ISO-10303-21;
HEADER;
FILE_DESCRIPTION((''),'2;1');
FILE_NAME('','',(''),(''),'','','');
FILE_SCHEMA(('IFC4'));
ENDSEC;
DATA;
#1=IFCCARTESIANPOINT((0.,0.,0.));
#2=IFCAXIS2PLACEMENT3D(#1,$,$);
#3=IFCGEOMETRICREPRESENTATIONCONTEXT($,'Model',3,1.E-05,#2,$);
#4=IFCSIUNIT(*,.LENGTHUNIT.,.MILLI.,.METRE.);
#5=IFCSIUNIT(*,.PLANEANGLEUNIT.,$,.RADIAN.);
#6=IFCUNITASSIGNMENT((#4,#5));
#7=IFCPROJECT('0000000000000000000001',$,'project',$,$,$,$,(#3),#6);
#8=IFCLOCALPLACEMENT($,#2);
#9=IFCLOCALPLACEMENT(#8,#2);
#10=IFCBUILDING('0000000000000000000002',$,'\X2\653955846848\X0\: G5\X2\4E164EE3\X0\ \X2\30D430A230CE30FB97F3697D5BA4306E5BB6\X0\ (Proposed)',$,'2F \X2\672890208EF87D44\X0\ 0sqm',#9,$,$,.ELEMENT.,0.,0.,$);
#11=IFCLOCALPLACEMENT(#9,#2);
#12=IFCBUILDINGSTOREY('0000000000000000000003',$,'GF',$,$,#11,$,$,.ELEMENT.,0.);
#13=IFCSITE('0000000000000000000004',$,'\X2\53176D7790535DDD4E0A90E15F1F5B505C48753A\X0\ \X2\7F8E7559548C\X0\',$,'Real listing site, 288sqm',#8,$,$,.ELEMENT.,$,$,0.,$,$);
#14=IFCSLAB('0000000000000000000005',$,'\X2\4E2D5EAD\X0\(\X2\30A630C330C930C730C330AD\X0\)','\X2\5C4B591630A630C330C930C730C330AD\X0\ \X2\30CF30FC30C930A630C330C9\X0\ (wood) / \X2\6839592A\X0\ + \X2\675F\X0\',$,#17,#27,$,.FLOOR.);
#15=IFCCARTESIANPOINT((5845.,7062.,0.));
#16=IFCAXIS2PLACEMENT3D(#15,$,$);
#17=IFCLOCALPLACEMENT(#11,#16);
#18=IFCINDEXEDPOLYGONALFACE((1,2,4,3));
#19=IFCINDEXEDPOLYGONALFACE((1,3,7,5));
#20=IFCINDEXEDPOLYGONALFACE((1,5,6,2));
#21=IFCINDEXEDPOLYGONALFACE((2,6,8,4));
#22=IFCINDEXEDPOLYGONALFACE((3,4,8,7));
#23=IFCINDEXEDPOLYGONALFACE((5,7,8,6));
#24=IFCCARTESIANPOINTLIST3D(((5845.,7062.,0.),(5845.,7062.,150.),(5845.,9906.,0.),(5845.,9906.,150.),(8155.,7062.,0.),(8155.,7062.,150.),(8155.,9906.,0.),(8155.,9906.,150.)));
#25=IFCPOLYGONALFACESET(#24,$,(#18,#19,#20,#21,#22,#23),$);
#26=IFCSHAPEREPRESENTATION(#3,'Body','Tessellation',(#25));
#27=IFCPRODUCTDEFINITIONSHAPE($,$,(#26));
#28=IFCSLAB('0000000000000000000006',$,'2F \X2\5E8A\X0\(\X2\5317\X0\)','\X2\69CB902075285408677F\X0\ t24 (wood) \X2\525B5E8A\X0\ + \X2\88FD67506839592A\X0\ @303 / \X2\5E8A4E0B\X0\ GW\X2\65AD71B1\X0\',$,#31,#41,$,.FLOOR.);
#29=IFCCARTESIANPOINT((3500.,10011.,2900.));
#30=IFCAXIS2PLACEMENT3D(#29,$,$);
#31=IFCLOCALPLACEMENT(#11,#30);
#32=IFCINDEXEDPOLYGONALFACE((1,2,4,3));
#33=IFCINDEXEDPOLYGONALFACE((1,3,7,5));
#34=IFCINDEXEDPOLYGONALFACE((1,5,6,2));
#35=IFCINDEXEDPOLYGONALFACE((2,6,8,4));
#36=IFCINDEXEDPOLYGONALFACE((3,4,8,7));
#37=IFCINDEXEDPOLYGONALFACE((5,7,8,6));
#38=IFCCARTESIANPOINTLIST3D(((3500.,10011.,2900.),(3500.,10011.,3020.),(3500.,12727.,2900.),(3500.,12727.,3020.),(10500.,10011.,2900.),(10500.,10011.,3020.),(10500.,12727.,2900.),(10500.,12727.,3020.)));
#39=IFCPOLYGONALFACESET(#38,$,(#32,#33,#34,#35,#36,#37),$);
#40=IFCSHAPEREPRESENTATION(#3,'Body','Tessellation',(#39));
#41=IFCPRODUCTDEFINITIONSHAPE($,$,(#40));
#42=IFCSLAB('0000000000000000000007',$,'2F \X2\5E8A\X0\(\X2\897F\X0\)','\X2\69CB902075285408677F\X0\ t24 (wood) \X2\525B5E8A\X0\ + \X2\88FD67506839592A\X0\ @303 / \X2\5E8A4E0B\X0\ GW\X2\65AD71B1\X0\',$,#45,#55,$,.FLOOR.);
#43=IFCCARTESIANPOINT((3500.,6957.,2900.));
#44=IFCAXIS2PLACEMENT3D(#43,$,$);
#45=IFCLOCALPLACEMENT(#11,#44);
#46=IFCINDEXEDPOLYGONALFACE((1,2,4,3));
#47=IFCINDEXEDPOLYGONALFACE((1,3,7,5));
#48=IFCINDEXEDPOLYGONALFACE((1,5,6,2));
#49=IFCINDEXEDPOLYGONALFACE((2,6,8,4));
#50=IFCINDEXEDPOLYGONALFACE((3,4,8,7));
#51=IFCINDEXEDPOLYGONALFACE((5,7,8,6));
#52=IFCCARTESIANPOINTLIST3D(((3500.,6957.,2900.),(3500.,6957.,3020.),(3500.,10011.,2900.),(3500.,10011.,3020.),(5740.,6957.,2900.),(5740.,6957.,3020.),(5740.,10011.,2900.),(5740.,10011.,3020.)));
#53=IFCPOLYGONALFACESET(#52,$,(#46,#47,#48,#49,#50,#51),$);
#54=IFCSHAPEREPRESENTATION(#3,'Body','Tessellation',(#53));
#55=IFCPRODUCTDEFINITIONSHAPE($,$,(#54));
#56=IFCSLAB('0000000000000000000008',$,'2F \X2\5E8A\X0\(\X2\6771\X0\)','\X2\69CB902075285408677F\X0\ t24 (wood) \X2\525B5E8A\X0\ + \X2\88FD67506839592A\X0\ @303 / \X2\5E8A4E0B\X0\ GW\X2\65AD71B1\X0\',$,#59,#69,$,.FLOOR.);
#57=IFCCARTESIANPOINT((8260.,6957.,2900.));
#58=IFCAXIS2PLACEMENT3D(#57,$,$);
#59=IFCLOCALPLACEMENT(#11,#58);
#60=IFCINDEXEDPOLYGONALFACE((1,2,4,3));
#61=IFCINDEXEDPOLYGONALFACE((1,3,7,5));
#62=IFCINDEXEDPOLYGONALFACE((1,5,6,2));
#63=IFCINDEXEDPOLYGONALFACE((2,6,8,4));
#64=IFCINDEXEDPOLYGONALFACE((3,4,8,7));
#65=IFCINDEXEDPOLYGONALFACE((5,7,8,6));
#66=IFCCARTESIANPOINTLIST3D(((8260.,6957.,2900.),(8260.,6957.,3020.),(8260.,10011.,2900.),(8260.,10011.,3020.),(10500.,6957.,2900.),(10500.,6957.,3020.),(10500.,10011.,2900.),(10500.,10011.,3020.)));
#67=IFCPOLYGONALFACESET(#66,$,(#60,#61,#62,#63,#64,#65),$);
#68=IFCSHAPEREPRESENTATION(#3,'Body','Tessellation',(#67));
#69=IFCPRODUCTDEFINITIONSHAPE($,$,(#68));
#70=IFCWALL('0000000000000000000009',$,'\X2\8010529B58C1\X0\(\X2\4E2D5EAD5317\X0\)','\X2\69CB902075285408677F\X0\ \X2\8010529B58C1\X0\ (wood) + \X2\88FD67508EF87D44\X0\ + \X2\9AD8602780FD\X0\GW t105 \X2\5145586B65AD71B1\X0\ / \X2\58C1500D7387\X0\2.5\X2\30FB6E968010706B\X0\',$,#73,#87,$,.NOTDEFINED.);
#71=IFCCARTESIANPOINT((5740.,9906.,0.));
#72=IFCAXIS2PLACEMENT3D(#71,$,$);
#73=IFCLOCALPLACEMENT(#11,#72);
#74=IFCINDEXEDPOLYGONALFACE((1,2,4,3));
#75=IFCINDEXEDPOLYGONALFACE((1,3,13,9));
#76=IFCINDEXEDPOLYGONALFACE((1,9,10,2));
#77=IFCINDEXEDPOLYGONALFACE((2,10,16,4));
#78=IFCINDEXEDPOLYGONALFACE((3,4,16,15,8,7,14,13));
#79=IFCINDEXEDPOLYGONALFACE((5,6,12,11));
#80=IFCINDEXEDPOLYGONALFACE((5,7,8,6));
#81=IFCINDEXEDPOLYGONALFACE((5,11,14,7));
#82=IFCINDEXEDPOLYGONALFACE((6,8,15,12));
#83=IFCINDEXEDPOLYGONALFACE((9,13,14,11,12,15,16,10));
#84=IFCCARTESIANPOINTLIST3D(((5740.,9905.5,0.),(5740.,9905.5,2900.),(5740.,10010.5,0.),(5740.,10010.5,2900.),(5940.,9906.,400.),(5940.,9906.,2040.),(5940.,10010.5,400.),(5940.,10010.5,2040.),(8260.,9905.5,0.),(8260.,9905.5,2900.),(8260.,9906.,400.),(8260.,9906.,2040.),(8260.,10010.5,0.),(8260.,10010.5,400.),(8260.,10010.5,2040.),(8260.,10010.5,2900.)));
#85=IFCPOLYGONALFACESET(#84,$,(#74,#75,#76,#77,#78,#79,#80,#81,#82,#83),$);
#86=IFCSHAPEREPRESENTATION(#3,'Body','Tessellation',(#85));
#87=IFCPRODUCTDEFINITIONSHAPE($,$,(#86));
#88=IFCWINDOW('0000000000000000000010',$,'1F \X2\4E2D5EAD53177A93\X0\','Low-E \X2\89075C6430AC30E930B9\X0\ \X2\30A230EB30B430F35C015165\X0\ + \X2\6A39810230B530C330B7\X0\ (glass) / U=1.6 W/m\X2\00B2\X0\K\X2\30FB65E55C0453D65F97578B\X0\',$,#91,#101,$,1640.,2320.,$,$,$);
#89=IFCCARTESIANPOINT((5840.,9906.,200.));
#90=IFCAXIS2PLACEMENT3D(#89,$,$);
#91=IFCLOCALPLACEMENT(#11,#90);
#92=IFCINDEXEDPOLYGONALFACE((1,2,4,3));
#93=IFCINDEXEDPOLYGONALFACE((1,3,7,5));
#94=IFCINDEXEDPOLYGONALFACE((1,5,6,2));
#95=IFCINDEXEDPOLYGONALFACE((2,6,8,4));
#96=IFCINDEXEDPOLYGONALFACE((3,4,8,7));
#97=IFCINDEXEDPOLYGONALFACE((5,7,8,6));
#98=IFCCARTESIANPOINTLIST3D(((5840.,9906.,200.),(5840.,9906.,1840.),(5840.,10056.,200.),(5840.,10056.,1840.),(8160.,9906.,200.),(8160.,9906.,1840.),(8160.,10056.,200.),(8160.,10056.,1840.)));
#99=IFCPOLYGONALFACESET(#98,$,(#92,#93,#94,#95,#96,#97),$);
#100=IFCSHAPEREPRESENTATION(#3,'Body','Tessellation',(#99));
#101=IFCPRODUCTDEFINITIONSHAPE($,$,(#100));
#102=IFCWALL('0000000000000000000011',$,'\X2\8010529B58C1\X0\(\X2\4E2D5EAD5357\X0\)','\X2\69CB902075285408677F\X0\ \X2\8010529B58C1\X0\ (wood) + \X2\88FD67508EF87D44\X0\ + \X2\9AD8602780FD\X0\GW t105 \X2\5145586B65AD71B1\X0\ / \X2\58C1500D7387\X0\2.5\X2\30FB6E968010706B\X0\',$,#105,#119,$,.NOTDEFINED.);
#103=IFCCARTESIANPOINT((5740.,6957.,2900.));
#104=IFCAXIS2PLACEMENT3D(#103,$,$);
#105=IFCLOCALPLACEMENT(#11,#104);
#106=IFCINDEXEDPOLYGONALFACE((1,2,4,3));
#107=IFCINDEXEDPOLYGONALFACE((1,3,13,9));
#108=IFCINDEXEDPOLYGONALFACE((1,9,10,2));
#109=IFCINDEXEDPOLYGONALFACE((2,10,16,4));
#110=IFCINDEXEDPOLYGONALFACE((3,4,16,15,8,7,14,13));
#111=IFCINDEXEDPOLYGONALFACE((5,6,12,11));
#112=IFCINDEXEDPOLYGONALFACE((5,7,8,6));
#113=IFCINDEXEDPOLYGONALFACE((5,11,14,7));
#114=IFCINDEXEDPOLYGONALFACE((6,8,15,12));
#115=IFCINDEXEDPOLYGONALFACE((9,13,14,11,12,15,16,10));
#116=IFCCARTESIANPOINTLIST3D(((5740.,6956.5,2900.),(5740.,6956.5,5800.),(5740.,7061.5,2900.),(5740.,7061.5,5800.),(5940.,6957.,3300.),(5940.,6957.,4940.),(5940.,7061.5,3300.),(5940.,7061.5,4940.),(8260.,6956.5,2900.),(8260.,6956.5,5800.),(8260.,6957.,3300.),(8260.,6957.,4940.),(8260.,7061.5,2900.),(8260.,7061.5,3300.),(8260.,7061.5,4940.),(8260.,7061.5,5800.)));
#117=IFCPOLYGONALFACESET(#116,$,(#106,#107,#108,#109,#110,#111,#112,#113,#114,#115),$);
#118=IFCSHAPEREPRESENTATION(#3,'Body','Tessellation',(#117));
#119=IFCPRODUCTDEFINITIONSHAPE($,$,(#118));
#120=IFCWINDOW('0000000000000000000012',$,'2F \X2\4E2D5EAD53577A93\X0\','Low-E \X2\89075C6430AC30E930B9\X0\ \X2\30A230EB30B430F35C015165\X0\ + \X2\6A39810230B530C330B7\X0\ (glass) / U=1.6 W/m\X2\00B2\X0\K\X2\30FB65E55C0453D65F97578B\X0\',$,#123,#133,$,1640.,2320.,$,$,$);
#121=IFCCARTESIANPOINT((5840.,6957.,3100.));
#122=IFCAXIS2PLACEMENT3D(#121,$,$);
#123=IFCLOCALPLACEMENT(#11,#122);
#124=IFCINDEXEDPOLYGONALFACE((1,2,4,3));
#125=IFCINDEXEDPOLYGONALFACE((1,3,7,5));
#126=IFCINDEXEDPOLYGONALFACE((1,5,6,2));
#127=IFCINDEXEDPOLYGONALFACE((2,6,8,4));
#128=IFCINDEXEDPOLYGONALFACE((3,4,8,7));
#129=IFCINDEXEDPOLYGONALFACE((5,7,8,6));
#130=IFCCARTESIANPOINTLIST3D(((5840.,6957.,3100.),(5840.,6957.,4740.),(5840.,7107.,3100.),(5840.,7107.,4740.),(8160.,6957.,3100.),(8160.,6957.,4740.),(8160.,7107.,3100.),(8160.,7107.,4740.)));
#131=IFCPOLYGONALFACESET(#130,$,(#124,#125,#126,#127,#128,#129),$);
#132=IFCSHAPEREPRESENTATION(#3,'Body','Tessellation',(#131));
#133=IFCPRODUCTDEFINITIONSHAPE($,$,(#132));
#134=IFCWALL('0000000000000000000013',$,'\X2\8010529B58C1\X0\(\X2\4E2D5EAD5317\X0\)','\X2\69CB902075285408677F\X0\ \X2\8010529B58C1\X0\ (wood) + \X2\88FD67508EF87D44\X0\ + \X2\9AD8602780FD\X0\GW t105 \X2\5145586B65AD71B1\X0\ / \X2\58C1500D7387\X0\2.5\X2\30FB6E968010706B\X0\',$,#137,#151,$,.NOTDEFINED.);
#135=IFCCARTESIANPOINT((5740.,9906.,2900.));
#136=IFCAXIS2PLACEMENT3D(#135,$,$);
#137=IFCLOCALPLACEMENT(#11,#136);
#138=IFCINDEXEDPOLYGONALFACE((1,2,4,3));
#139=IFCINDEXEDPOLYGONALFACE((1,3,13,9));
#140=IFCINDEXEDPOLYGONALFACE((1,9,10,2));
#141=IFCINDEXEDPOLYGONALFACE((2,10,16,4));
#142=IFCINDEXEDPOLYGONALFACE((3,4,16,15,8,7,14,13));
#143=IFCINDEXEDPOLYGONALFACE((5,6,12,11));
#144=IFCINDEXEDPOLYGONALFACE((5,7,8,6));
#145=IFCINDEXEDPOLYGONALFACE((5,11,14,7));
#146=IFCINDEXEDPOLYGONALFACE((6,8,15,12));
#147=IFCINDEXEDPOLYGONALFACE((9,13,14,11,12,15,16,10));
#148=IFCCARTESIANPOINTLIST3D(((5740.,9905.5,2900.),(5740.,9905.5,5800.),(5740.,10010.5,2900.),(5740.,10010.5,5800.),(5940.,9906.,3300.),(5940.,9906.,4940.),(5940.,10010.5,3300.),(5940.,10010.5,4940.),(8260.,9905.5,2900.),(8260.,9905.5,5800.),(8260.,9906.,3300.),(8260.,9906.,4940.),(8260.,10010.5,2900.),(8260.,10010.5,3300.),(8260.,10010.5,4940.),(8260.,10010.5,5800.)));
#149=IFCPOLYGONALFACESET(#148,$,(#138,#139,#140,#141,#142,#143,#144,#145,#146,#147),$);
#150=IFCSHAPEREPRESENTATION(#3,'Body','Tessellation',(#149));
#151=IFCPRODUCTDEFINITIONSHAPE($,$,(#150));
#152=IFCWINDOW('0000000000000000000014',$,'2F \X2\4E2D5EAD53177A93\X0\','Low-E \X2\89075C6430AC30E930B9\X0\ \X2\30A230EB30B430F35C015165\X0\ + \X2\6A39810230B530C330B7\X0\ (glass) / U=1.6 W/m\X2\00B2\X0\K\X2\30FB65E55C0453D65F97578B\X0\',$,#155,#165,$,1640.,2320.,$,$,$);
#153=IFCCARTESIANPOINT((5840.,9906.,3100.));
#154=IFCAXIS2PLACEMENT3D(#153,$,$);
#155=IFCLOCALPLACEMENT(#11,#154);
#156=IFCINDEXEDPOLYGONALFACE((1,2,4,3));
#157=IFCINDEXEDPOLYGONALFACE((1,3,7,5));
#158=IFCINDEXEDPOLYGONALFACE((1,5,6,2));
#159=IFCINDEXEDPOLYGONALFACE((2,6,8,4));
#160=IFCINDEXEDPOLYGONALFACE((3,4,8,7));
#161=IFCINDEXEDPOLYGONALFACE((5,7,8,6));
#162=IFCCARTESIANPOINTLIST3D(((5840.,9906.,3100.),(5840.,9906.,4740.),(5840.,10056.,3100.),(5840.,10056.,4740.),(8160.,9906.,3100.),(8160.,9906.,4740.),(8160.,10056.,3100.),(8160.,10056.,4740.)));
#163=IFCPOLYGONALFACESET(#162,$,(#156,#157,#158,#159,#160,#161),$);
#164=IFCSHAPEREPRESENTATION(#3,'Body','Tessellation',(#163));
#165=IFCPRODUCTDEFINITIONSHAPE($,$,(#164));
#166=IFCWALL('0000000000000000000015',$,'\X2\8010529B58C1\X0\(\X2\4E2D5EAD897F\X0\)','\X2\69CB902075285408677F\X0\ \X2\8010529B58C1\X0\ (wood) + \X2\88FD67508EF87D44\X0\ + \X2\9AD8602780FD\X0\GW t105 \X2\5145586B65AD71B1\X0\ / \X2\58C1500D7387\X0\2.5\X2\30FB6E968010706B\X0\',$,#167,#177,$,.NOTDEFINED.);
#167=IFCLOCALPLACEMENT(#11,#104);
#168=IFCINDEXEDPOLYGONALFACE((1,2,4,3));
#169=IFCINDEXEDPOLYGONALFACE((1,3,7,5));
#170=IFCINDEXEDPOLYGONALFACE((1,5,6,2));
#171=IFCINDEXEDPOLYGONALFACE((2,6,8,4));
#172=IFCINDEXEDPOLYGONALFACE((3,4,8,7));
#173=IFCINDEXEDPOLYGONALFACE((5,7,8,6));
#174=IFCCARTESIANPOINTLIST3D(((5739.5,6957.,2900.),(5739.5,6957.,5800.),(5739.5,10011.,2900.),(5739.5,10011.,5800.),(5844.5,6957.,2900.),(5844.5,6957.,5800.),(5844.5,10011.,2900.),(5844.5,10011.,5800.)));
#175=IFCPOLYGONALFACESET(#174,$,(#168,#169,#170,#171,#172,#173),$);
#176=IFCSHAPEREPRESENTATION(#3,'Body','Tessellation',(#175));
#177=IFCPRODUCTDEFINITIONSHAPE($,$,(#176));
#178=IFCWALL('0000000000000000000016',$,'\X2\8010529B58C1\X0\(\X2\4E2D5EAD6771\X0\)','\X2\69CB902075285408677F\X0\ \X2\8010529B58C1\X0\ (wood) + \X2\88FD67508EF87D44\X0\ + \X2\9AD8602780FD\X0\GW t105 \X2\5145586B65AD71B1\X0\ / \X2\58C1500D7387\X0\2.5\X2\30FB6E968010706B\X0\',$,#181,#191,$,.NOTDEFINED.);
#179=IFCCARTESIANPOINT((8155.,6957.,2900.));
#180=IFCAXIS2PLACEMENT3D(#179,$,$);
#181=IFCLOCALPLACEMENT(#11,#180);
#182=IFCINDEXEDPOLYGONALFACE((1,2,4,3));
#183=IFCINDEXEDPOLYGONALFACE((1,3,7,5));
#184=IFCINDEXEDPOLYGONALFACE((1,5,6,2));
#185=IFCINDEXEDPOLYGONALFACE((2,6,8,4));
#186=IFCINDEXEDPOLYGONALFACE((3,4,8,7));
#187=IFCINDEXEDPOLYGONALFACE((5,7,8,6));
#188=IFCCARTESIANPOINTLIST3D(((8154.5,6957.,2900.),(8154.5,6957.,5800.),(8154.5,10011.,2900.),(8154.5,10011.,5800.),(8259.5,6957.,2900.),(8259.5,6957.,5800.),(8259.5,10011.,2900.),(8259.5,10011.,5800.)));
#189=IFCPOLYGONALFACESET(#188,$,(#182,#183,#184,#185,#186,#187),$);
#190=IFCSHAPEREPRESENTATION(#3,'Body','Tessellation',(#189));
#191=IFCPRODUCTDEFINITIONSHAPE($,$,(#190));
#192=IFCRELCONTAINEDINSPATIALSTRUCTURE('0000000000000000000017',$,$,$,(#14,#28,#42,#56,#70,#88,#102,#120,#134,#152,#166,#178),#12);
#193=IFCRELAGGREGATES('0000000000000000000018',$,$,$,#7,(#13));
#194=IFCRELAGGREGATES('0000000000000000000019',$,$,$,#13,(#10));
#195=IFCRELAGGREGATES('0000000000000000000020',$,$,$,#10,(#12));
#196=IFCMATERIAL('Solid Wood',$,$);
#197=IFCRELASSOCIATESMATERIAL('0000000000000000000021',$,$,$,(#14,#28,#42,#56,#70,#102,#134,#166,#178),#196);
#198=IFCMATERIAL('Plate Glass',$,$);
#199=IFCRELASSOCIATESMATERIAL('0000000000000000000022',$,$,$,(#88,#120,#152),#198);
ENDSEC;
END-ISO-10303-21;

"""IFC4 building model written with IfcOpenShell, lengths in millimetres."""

from ifc_helpers import new_model, si_unit, frame, frame_2d, origin, place, context, project, spatial, rectangle, extrude, material, element, fill, save


model = new_model("IFC4")

# Units and contexts
model_context = context("Model", 3, precision=1e-05, world=origin())
ifc_project = project(units=[si_unit("LENGTHUNIT", "METRE", prefix="MILLI"), si_unit("PLANEANGLEUNIT", "RADIAN")], contexts=[model_context])

# Site, building, storey
site_placement = place(None, origin())
site = spatial("IfcSite", under=ifc_project, at=site_placement, Name="北海道川上郡弟子屈町 美留和", ObjectType="Real listing site, 288sqm", CompositionType="ELEMENT", RefElevation=0.0)
building_placement = place(site_placement, origin())
building = spatial("IfcBuilding", under=site, at=building_placement, Name="改善案: G5世代 ピアノ・音楽室の家 (Proposed)", ObjectType="2F 木造軸組 0sqm", CompositionType="ELEMENT", ElevationOfRefHeight=0.0, ElevationOfTerrain=0.0)
storey_placement = place(building_placement, origin())
storey = spatial("IfcBuildingStorey", under=building, at=storey_placement, Name="GF", CompositionType="ELEMENT", Elevation=0.0)

# Slabs
ifc_material_1 = material(Name="Solid Wood")
slab_1_placement = place(storey_placement, frame((5845.0, 7062.0, 0.0)))
element("IfcSlab", 1, at=slab_1_placement, inside=storey, material=ifc_material_1, Name="中庭(ウッドデッキ)", Description="屋外ウッドデッキ ハードウッド (wood) / 根太 + 束", PredefinedType="FLOOR", context=model_context, shape_type="SweptSolid", body=[
    extrude(rectangle(XDim=2310.0, YDim=2844.0, at=frame_2d((1155.0, 1422.0))), frame((5845.0, 7062.0, 0.0)), (0.0, 0.0, 1.0), 150.0),
])
slab_2_placement = place(storey_placement, frame((3500.0, 10011.0, 2900.0)))
element("IfcSlab", 2, at=slab_2_placement, inside=storey, material=ifc_material_1, Name="2F 床(北)", Description="構造用合板 t24 (wood) 剛床 + 製材根太 @303 / 床下 GW断熱", PredefinedType="FLOOR", context=model_context, shape_type="SweptSolid", body=[
    extrude(rectangle(XDim=7000.0, YDim=2716.0, at=frame_2d((3500.0, 1358.0))), frame((3500.0, 10011.0, 2900.0)), (0.0, 0.0, 1.0), 120.0),
])
slab_3_placement = place(storey_placement, frame((3500.0, 6957.0, 2900.0)))
element("IfcSlab", 3, at=slab_3_placement, inside=storey, material=ifc_material_1, Name="2F 床(西)", Description="構造用合板 t24 (wood) 剛床 + 製材根太 @303 / 床下 GW断熱", PredefinedType="FLOOR", context=model_context, shape_type="SweptSolid", body=[
    extrude(rectangle(XDim=2240.0, YDim=3054.0, at=frame_2d((1120.0, 1527.0))), frame((3500.0, 6957.0, 2900.0)), (0.0, 0.0, 1.0), 120.0),
])
slab_4_placement = place(storey_placement, frame((8260.0, 6957.0, 2900.0)))
element("IfcSlab", 4, at=slab_4_placement, inside=storey, material=ifc_material_1, Name="2F 床(東)", Description="構造用合板 t24 (wood) 剛床 + 製材根太 @303 / 床下 GW断熱", PredefinedType="FLOOR", context=model_context, shape_type="SweptSolid", body=[
    extrude(rectangle(XDim=2240.0, YDim=3054.0, at=frame_2d((1120.0, 1527.0))), frame((8260.0, 6957.0, 2900.0)), (0.0, 0.0, 1.0), 120.0),
])

# Wall, opening, window
wall_1_placement = place(storey_placement, frame((5740.0, 9906.0, 0.0)))
wall_1 = element("IfcWall", 5, at=wall_1_placement, inside=storey, material=ifc_material_1, Name="耐力壁(中庭北)", Description="構造用合板 耐力壁 (wood) + 製材軸組 + 高性能GW t105 充填断熱 / 壁倍率2.5・準耐火", PredefinedType="NOTDEFINED", context=model_context, shape_type="SweptSolid", body=[
    extrude(rectangle(XDim=2520.0, YDim=105.0, at=frame_2d((1260.0, 52.0))), frame((5740.0, 9906.0, 0.0)), (0.0, 0.0, 1.0), 2900.0),
])
opening_1_placement = place(storey_placement, frame((5840.0, 9906.0, 200.0)))
opening_1 = element("IfcOpeningElement", 6, at=opening_1_placement, cuts=wall_1, PredefinedType="NOTDEFINED", context=model_context, shape_type="SweptSolid", body=[
    extrude(rectangle(XDim=2320.0, YDim=150.0, at=frame_2d((1160.0, 75.0))), frame((5840.0, 9906.0, 200.0)), (0.0, 0.0, 1.0), 1640.0),
])
ifc_material_2 = material(Name="Plate Glass")
window_1_placement = place(storey_placement, frame((5840.0, 9906.0, 200.0)))
window_1 = element("IfcWindow", 7, at=window_1_placement, inside=storey, material=ifc_material_2, Name="1F 中庭北窓", Description="Low-E 複層ガラス アルゴン封入 + 樹脂サッシ (glass) / U=1.6 W/m²K・日射取得型", OverallHeight=1640.0, OverallWidth=2320.0, context=model_context, shape_type="SweptSolid", body=[
    extrude(rectangle(XDim=2320.0, YDim=150.0, at=frame_2d((1160.0, 75.0))), frame((5840.0, 9906.0, 200.0)), (0.0, 0.0, 1.0), 1640.0),
])
fill(opening_1, window_1)

# Walls, openings, windows
wall_2_placement = place(storey_placement, frame((5740.0, 6957.0, 2900.0)))
wall_2 = element("IfcWall", 8, at=wall_2_placement, inside=storey, material=ifc_material_1, Name="耐力壁(中庭南)", Description="構造用合板 耐力壁 (wood) + 製材軸組 + 高性能GW t105 充填断熱 / 壁倍率2.5・準耐火", PredefinedType="NOTDEFINED", context=model_context, shape_type="SweptSolid", body=[
    extrude(rectangle(XDim=2520.0, YDim=105.0, at=frame_2d((1260.0, 52.0))), frame((5740.0, 6957.0, 2900.0)), (0.0, 0.0, 1.0), 2900.0),
])
opening_2_placement = place(storey_placement, frame((5840.0, 6957.0, 3100.0)))
opening_2 = element("IfcOpeningElement", 9, at=opening_2_placement, cuts=wall_2, PredefinedType="NOTDEFINED", context=model_context, shape_type="SweptSolid", body=[
    extrude(rectangle(XDim=2320.0, YDim=150.0, at=frame_2d((1160.0, 75.0))), frame((5840.0, 6957.0, 3100.0)), (0.0, 0.0, 1.0), 1640.0),
])
window_2_placement = place(storey_placement, frame((5840.0, 6957.0, 3100.0)))
window_2 = element("IfcWindow", 10, at=window_2_placement, inside=storey, material=ifc_material_2, Name="2F 中庭南窓", Description="Low-E 複層ガラス アルゴン封入 + 樹脂サッシ (glass) / U=1.6 W/m²K・日射取得型", OverallHeight=1640.0, OverallWidth=2320.0, context=model_context, shape_type="SweptSolid", body=[
    extrude(rectangle(XDim=2320.0, YDim=150.0, at=frame_2d((1160.0, 75.0))), frame((5840.0, 6957.0, 3100.0)), (0.0, 0.0, 1.0), 1640.0),
])
fill(opening_2, window_2)
wall_3_placement = place(storey_placement, frame((5740.0, 9906.0, 2900.0)))
wall_3 = element("IfcWall", 11, at=wall_3_placement, inside=storey, material=ifc_material_1, Name="耐力壁(中庭北)", Description="構造用合板 耐力壁 (wood) + 製材軸組 + 高性能GW t105 充填断熱 / 壁倍率2.5・準耐火", PredefinedType="NOTDEFINED", context=model_context, shape_type="SweptSolid", body=[
    extrude(rectangle(XDim=2520.0, YDim=105.0, at=frame_2d((1260.0, 52.0))), frame((5740.0, 9906.0, 2900.0)), (0.0, 0.0, 1.0), 2900.0),
])
opening_3_placement = place(storey_placement, frame((5840.0, 9906.0, 3100.0)))
opening_3 = element("IfcOpeningElement", 12, at=opening_3_placement, cuts=wall_3, PredefinedType="NOTDEFINED", context=model_context, shape_type="SweptSolid", body=[
    extrude(rectangle(XDim=2320.0, YDim=150.0, at=frame_2d((1160.0, 75.0))), frame((5840.0, 9906.0, 3100.0)), (0.0, 0.0, 1.0), 1640.0),
])
window_3_placement = place(storey_placement, frame((5840.0, 9906.0, 3100.0)))
window_3 = element("IfcWindow", 13, at=window_3_placement, inside=storey, material=ifc_material_2, Name="2F 中庭北窓", Description="Low-E 複層ガラス アルゴン封入 + 樹脂サッシ (glass) / U=1.6 W/m²K・日射取得型", OverallHeight=1640.0, OverallWidth=2320.0, context=model_context, shape_type="SweptSolid", body=[
    extrude(rectangle(XDim=2320.0, YDim=150.0, at=frame_2d((1160.0, 75.0))), frame((5840.0, 9906.0, 3100.0)), (0.0, 0.0, 1.0), 1640.0),
])
fill(opening_3, window_3)

# Walls
wall_4_placement = place(storey_placement, frame((5740.0, 6957.0, 2900.0)))
element("IfcWall", 14, at=wall_4_placement, inside=storey, material=ifc_material_1, Name="耐力壁(中庭西)", Description="構造用合板 耐力壁 (wood) + 製材軸組 + 高性能GW t105 充填断熱 / 壁倍率2.5・準耐火", PredefinedType="NOTDEFINED", context=model_context, shape_type="SweptSolid", body=[
    extrude(rectangle(XDim=105.0, YDim=3054.0, at=frame_2d((52.0, 1527.0))), frame((5740.0, 6957.0, 2900.0)), (0.0, 0.0, 1.0), 2900.0),
])
wall_5_placement = place(storey_placement, frame((8155.0, 6957.0, 2900.0)))
element("IfcWall", 15, at=wall_5_placement, inside=storey, material=ifc_material_1, Name="耐力壁(中庭東)", Description="構造用合板 耐力壁 (wood) + 製材軸組 + 高性能GW t105 充填断熱 / 壁倍率2.5・準耐火", PredefinedType="NOTDEFINED", context=model_context, shape_type="SweptSolid", body=[
    extrude(rectangle(XDim=105.0, YDim=3054.0, at=frame_2d((52.0, 1527.0))), frame((8155.0, 6957.0, 2900.0)), (0.0, 0.0, 1.0), 2900.0),
])

save(model, "model.ifc")
